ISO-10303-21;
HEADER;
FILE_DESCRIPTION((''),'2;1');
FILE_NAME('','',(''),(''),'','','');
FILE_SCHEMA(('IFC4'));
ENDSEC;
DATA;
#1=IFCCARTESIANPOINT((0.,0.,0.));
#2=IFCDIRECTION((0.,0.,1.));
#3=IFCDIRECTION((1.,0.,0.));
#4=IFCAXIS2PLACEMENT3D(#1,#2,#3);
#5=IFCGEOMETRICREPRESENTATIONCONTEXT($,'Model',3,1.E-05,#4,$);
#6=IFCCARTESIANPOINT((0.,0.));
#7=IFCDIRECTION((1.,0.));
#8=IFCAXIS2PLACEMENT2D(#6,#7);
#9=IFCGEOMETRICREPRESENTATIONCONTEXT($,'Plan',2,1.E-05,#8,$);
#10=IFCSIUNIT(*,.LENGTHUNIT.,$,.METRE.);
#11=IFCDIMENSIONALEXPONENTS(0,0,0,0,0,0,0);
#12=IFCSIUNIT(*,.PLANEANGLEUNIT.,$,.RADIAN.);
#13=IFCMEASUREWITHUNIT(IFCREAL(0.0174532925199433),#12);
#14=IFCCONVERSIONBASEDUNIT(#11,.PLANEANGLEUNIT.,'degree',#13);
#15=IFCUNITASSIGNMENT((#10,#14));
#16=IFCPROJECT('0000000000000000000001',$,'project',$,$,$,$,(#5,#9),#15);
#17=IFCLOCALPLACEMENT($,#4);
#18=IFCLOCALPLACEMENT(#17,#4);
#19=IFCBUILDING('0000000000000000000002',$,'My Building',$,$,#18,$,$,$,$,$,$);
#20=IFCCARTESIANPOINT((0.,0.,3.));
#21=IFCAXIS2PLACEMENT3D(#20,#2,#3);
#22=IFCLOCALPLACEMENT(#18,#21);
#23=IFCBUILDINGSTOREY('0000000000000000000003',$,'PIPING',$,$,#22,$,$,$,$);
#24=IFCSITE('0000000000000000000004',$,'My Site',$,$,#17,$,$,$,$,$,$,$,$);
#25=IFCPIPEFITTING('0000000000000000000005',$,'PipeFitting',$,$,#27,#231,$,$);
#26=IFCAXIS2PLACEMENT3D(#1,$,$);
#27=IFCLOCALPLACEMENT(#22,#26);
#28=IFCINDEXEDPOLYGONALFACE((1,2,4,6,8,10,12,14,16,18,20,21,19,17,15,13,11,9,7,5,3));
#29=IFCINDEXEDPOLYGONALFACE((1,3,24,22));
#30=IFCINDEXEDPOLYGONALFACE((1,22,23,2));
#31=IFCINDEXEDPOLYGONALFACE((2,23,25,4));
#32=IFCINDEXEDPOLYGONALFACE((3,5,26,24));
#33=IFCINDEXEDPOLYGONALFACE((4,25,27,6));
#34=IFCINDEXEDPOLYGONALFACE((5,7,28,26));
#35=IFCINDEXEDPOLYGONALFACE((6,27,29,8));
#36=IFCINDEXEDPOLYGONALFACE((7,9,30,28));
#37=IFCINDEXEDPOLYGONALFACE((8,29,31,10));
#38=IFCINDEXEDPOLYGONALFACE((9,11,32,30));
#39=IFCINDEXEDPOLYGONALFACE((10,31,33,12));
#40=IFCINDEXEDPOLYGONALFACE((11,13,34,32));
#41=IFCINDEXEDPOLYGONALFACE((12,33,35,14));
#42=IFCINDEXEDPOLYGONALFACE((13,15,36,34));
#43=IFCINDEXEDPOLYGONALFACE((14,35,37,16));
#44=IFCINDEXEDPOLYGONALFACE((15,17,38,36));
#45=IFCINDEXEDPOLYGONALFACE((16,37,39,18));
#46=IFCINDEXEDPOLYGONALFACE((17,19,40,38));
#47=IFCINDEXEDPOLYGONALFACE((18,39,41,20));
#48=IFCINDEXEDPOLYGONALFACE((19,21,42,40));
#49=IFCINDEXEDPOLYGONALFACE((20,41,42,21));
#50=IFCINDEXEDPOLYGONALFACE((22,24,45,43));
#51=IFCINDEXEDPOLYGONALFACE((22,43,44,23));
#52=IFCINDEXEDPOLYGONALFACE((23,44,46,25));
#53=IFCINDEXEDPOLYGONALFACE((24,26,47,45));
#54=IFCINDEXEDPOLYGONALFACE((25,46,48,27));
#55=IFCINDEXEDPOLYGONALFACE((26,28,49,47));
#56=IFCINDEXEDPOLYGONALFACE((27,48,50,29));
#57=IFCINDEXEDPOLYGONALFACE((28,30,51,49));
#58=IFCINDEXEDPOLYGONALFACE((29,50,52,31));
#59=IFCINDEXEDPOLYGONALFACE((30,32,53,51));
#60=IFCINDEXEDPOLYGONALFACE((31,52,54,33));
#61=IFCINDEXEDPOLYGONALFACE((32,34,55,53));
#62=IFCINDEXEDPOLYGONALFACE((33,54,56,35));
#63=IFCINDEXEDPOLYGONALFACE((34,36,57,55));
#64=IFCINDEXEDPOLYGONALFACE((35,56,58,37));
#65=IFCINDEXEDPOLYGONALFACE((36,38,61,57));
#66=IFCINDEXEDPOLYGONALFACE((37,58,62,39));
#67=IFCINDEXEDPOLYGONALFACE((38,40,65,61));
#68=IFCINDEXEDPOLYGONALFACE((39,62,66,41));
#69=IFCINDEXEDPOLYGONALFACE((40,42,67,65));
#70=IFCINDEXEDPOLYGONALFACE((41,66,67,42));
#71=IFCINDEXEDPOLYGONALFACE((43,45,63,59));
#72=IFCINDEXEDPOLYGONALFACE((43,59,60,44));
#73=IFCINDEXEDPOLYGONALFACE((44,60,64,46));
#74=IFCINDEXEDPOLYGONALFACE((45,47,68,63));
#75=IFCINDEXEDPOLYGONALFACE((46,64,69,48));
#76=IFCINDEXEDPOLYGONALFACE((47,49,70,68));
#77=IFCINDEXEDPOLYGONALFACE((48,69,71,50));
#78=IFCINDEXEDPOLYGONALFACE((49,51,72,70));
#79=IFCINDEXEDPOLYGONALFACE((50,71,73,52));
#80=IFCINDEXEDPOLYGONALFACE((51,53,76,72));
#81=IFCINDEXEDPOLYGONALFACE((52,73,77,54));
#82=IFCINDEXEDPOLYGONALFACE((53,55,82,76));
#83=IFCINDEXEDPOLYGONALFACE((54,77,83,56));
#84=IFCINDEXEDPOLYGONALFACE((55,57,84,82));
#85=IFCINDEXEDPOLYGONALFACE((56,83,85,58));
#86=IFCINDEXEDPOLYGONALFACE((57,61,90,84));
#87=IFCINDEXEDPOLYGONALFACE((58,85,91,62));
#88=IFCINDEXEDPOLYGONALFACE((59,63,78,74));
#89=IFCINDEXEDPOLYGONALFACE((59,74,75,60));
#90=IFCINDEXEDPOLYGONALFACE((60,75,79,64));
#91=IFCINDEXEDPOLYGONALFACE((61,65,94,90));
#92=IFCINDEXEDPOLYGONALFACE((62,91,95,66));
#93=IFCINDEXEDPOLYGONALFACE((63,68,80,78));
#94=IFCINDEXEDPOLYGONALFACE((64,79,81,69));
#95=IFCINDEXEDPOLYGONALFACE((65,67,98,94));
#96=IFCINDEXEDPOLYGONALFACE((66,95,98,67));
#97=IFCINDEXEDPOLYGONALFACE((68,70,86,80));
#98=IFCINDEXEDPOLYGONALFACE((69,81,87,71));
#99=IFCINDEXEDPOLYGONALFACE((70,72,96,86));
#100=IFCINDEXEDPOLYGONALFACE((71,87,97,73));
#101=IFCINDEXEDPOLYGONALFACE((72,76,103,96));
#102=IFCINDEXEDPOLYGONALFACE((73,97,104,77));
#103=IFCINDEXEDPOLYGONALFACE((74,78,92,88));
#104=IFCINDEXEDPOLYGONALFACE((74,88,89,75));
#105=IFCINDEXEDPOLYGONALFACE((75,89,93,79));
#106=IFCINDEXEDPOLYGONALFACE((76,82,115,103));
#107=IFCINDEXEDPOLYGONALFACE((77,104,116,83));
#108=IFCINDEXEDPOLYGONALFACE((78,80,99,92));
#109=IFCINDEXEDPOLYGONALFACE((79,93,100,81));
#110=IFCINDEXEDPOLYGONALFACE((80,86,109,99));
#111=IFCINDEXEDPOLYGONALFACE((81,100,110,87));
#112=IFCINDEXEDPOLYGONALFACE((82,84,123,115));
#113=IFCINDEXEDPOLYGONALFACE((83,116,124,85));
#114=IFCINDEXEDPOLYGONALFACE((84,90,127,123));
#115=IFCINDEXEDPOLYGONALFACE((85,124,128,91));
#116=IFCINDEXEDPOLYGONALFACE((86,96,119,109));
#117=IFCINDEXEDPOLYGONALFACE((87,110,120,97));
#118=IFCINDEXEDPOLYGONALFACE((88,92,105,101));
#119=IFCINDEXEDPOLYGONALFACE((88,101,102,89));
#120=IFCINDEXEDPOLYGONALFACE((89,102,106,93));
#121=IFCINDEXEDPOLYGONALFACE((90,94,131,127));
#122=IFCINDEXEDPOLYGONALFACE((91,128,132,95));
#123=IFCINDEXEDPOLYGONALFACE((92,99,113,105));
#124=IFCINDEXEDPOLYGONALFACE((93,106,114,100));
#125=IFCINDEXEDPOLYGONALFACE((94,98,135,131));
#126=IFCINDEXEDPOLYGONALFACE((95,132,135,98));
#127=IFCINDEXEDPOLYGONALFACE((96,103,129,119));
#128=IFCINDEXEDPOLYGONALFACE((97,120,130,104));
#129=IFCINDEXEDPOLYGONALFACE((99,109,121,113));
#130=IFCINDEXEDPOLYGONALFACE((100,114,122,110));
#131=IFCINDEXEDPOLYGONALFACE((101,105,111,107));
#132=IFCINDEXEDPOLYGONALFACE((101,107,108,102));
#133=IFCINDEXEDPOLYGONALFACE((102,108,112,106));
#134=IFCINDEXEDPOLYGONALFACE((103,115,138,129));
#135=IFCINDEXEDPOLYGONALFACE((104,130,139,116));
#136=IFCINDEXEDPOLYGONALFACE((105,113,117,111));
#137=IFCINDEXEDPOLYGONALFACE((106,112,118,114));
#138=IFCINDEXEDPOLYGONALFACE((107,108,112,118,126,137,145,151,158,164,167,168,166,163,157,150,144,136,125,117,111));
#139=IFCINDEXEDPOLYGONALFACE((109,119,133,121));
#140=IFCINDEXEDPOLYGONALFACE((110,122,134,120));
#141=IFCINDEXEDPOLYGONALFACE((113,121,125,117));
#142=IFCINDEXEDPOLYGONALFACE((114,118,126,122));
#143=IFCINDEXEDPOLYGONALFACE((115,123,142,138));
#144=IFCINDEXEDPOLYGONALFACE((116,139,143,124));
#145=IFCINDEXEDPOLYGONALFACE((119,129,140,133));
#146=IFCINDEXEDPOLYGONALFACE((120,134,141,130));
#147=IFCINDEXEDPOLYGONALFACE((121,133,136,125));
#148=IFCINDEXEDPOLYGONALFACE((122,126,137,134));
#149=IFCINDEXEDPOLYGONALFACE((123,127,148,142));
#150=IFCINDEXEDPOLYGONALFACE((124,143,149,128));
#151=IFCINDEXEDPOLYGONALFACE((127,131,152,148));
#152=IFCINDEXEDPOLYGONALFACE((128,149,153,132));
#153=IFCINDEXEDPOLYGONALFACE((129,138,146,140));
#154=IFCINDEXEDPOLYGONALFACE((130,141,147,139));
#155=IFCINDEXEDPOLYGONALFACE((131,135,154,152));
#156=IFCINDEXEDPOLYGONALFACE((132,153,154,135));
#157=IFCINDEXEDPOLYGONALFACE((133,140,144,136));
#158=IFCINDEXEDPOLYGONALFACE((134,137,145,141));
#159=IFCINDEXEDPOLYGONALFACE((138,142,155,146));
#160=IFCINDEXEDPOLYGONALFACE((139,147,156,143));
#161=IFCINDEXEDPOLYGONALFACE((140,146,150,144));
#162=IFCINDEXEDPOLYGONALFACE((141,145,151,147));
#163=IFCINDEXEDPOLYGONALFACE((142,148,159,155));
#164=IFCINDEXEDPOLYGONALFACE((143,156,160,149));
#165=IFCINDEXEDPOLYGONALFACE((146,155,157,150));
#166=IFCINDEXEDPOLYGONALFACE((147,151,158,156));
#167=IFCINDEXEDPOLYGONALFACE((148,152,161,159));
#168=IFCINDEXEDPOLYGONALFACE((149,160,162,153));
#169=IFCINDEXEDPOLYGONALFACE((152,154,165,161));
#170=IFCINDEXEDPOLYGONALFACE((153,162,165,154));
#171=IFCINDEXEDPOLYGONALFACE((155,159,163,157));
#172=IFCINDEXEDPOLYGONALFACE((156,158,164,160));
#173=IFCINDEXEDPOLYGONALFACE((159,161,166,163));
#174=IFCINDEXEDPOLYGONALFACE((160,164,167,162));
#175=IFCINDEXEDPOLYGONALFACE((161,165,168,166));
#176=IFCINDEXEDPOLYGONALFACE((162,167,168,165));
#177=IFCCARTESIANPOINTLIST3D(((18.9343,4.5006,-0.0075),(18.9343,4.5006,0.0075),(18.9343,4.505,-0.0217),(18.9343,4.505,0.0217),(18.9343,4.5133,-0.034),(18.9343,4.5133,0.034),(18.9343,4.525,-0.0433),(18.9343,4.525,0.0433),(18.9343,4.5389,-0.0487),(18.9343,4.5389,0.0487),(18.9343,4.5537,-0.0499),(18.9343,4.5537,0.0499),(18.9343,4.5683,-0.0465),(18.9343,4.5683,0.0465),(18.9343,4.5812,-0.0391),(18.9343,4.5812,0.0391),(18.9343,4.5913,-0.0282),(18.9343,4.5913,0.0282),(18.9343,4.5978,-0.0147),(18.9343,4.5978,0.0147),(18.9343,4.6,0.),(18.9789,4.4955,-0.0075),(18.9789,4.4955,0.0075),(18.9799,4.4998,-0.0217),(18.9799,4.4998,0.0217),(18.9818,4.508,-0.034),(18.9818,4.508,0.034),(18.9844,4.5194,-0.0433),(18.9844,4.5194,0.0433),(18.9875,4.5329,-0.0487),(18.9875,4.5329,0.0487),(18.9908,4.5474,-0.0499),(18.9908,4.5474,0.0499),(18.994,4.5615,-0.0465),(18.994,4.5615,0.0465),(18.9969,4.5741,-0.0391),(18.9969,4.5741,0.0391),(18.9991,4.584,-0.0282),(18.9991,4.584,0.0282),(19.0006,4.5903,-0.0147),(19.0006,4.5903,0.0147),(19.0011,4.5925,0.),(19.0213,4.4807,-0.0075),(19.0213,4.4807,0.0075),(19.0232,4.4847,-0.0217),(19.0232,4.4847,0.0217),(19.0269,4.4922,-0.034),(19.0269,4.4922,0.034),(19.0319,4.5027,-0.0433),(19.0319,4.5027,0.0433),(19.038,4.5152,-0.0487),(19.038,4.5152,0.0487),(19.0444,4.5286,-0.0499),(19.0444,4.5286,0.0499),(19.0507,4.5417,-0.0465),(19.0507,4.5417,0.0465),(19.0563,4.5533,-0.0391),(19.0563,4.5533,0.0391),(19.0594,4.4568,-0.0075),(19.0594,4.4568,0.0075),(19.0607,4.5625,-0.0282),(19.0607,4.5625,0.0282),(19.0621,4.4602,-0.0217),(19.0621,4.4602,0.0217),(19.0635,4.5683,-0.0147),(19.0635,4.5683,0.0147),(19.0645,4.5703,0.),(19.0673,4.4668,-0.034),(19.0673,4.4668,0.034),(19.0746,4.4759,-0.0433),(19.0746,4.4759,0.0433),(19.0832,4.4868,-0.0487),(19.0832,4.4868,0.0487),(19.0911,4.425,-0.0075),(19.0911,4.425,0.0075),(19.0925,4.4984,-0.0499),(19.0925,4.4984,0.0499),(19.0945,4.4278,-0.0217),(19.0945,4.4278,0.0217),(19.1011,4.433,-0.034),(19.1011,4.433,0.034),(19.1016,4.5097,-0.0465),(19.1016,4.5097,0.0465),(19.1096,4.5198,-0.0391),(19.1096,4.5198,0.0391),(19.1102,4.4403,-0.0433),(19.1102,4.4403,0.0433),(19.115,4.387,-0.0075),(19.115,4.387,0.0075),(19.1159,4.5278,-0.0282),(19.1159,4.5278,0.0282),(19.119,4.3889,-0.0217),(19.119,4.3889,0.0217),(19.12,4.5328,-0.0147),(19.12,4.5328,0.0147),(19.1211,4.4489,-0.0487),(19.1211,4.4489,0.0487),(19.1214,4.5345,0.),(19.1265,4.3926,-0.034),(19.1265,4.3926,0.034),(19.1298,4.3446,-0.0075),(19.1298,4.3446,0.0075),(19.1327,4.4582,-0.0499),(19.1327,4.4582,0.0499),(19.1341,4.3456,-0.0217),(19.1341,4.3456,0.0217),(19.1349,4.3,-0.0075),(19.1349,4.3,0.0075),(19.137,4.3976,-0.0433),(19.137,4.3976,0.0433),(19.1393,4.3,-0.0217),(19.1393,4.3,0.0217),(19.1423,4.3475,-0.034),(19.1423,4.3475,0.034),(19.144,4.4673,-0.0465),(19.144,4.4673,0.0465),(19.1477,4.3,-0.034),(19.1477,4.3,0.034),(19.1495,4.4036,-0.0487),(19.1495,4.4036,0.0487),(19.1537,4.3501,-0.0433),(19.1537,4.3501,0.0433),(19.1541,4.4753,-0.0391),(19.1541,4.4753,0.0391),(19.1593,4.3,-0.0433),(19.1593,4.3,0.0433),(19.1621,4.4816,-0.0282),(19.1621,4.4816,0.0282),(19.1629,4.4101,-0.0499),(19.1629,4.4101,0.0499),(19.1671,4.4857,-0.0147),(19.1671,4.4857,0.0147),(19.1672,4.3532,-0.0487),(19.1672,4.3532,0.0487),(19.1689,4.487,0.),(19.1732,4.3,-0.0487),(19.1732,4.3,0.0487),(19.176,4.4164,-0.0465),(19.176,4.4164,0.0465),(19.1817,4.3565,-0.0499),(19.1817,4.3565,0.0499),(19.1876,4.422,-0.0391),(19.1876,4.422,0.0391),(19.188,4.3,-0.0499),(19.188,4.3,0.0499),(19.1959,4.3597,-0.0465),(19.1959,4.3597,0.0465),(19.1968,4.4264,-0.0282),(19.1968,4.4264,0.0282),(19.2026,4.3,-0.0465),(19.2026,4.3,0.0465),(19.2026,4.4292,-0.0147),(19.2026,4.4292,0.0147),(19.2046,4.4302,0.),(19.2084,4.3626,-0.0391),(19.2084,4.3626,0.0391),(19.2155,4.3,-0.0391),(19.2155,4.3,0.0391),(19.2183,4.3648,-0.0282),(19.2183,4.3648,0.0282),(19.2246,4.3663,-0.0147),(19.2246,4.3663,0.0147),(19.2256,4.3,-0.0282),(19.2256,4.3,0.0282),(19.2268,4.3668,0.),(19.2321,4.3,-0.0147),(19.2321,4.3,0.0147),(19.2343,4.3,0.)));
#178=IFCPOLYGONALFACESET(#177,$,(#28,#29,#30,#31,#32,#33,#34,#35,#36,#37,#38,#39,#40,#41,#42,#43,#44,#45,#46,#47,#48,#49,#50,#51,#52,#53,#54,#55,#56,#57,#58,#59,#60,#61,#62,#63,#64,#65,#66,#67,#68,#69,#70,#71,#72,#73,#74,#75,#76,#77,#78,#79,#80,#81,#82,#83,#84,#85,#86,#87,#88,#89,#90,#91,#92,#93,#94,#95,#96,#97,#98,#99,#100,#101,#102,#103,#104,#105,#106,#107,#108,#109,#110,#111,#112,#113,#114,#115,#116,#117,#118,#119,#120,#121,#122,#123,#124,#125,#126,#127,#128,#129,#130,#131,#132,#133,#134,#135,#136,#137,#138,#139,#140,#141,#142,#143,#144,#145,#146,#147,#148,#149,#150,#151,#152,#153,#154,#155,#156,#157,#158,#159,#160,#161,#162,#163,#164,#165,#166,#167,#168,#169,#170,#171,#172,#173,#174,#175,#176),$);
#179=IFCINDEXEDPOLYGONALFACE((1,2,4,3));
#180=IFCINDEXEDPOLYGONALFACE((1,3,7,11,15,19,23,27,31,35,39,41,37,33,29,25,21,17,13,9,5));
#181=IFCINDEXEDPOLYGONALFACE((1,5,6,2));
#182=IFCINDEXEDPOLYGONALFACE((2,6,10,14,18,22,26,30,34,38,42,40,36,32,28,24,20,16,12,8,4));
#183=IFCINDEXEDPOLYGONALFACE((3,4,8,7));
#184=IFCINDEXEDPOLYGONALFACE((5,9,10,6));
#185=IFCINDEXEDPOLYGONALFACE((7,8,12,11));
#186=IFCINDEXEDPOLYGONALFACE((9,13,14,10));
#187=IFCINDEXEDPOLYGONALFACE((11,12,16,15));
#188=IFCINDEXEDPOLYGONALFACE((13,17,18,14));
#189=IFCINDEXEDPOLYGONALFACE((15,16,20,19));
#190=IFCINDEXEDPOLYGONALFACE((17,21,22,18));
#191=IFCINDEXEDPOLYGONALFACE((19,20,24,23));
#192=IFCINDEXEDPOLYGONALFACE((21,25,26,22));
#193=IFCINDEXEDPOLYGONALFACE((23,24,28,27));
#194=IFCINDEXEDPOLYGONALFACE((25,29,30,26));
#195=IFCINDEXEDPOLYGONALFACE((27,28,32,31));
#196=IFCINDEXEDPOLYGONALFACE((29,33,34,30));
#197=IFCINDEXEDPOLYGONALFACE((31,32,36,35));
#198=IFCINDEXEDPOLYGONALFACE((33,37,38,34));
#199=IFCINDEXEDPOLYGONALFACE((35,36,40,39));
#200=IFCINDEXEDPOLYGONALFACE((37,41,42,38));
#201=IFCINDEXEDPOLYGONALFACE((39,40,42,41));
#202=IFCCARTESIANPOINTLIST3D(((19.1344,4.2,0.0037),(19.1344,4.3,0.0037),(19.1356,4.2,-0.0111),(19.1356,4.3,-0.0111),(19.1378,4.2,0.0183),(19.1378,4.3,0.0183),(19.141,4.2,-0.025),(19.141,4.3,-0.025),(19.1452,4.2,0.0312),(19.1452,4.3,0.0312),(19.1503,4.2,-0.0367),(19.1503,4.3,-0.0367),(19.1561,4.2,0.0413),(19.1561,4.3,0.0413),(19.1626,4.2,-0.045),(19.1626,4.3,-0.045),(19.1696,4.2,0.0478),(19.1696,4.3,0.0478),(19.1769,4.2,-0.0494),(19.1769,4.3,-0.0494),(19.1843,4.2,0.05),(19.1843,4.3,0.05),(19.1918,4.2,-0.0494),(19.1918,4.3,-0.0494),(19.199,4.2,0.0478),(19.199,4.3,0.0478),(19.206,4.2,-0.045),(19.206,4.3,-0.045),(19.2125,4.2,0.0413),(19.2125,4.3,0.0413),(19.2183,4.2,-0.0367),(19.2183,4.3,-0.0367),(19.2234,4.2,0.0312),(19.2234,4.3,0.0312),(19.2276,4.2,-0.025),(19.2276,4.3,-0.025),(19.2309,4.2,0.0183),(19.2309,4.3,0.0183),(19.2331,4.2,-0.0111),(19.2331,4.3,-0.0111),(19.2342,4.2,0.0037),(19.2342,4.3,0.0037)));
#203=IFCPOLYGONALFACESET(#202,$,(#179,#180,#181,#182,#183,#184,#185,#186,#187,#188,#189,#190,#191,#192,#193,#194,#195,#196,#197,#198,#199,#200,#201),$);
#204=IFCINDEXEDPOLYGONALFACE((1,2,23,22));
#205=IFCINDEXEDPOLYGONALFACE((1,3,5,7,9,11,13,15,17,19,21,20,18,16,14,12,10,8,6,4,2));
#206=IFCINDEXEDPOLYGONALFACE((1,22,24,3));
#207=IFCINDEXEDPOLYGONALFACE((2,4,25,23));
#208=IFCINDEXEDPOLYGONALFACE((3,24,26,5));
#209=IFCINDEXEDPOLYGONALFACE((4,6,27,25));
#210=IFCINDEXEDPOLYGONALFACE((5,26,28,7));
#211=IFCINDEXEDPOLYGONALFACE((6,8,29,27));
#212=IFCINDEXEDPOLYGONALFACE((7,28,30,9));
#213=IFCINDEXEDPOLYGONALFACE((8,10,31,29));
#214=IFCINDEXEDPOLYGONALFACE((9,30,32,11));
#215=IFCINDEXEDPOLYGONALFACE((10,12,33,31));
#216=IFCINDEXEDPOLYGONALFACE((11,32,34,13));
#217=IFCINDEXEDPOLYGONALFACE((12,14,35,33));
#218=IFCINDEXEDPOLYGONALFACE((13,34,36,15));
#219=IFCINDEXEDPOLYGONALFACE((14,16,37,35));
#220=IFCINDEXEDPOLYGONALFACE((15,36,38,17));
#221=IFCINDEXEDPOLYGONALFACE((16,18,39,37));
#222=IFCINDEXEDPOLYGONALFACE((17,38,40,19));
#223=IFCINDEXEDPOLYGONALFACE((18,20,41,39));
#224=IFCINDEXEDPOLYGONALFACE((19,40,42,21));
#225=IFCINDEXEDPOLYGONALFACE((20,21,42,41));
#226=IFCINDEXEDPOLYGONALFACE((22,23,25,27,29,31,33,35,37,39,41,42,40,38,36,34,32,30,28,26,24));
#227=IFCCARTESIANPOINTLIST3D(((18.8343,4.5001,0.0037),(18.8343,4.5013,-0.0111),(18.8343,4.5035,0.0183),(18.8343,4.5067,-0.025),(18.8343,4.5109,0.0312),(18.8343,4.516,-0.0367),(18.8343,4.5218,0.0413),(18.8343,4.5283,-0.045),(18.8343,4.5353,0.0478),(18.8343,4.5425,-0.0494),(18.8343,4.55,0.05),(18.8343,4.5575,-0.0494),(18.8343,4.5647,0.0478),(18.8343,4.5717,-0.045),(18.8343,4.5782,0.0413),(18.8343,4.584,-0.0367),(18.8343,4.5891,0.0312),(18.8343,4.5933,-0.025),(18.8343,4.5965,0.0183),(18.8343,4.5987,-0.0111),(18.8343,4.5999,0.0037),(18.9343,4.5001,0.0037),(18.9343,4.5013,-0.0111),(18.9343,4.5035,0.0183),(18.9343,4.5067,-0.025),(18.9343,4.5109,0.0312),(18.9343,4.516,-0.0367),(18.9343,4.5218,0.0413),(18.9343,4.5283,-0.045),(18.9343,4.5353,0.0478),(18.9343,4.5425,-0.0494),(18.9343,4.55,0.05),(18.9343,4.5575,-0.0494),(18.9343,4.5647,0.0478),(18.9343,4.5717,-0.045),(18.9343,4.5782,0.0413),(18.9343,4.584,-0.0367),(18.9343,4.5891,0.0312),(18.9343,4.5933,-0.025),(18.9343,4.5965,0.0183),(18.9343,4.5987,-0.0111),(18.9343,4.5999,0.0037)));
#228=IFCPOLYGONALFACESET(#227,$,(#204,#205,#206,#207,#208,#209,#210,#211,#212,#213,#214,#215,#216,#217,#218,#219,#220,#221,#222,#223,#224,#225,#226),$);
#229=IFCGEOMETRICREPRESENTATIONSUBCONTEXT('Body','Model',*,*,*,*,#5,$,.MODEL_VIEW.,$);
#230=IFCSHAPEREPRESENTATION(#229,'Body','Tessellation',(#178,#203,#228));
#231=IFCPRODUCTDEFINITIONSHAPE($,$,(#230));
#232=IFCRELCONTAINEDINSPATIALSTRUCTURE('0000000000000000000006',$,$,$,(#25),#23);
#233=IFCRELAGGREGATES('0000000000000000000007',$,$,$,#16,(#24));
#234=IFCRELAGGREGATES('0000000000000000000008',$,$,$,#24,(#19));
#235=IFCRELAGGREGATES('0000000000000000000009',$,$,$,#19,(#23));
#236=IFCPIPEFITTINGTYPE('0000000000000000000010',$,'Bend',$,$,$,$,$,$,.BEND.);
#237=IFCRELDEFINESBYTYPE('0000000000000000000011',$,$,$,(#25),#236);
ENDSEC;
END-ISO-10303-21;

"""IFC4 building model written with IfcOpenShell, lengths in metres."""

from ifc_helpers import new_model, entity, si_unit, converted_unit, frame, origin_with_axes, origin_2d_with_axis, place, context, subcontext, project, spatial, circle, extrude, source, transform, mapped, type_object, type_shapes, element, save


model = new_model("IFC4")

# Units and contexts
model_context = context("Model", 3, precision=1e-05, world=origin_with_axes())
plan_context = context("Plan", 2, precision=1e-05, world=origin_2d_with_axis())
body_context = subcontext(model_context, "Body", "Model", "MODEL_VIEW")
ifc_project = project(units=[si_unit("LENGTHUNIT", "METRE"), converted_unit("PLANEANGLEUNIT", "degree", entity("IfcReal", 0.0174532925199433), si_unit("PLANEANGLEUNIT", "RADIAN"), dimensions=[0, 0, 0, 0, 0, 0, 0])], contexts=[model_context, plan_context])

# Site, building, storey
site_placement = place(None, origin_with_axes())
site = spatial("IfcSite", under=ifc_project, at=site_placement, Name="My Site")
building_placement = place(site_placement, origin_with_axes())
building = spatial("IfcBuilding", under=site, at=building_placement, Name="My Building")
storey_placement = place(building_placement, frame((0.0, 0.0, 3.0), z_axis=(0.0, 0.0, 1.0), x_axis=(1.0, 0.0, 0.0)))
storey = spatial("IfcBuildingStorey", under=building, at=storey_placement, Name="PIPING")

# Pipe fitting
pipe_fitting_type = type_object("IfcPipeFittingType", Name="Bend", PredefinedType="BEND")
shared_shape = source(origin_with_axes(), body_context, "Body", "SolidModel", [
    entity("IfcSweptDiskSolid", entity("IfcIndexedPolyCurve", entity("IfcCartesianPointList3D", [[0.0, 0.0, 0.1], [0.0, -0.0732, 0.2768], [0.0, -0.25, 0.35]]), [entity("IfcArcIndex", [1, 2, 3])]), 0.05),
    extrude(circle(Radius=0.05), origin_with_axes(), (0.0, 0.0, 1.0), 0.1),
    extrude(circle(Radius=0.05), frame((0.0, -0.25, 0.35), z_axis=(0.0, -1.0, 0.0), x_axis=(1.0, 0.0, 0.0)), (0.0, 0.0, 1.0), 0.1),
])
type_shapes(pipe_fitting_type, [shared_shape])
for number, where, z_axis, x_axis, name in (
    (1, (19.1843, 4.2, 0.0), (0.0, 1.0, 0.0), (0.0, 0.0, 1.0), "PipeFitting"),
):
    element("IfcPipeFitting", number, at=place(storey_placement, frame(where, z_axis=z_axis, x_axis=x_axis)), inside=storey, type_object=pipe_fitting_type, Name=name, context=body_context, shape_type="MappedRepresentation", body=[
        mapped(shared_shape, transform((0.0, 0.0, 0.0), x_axis=(1.0, 0.0, 0.0), y_axis=(0.0, 1.0, 0.0), z_axis=(0.0, 0.0, 1.0), scale=1.0)),
    ])

save(model, "model.ifc")
